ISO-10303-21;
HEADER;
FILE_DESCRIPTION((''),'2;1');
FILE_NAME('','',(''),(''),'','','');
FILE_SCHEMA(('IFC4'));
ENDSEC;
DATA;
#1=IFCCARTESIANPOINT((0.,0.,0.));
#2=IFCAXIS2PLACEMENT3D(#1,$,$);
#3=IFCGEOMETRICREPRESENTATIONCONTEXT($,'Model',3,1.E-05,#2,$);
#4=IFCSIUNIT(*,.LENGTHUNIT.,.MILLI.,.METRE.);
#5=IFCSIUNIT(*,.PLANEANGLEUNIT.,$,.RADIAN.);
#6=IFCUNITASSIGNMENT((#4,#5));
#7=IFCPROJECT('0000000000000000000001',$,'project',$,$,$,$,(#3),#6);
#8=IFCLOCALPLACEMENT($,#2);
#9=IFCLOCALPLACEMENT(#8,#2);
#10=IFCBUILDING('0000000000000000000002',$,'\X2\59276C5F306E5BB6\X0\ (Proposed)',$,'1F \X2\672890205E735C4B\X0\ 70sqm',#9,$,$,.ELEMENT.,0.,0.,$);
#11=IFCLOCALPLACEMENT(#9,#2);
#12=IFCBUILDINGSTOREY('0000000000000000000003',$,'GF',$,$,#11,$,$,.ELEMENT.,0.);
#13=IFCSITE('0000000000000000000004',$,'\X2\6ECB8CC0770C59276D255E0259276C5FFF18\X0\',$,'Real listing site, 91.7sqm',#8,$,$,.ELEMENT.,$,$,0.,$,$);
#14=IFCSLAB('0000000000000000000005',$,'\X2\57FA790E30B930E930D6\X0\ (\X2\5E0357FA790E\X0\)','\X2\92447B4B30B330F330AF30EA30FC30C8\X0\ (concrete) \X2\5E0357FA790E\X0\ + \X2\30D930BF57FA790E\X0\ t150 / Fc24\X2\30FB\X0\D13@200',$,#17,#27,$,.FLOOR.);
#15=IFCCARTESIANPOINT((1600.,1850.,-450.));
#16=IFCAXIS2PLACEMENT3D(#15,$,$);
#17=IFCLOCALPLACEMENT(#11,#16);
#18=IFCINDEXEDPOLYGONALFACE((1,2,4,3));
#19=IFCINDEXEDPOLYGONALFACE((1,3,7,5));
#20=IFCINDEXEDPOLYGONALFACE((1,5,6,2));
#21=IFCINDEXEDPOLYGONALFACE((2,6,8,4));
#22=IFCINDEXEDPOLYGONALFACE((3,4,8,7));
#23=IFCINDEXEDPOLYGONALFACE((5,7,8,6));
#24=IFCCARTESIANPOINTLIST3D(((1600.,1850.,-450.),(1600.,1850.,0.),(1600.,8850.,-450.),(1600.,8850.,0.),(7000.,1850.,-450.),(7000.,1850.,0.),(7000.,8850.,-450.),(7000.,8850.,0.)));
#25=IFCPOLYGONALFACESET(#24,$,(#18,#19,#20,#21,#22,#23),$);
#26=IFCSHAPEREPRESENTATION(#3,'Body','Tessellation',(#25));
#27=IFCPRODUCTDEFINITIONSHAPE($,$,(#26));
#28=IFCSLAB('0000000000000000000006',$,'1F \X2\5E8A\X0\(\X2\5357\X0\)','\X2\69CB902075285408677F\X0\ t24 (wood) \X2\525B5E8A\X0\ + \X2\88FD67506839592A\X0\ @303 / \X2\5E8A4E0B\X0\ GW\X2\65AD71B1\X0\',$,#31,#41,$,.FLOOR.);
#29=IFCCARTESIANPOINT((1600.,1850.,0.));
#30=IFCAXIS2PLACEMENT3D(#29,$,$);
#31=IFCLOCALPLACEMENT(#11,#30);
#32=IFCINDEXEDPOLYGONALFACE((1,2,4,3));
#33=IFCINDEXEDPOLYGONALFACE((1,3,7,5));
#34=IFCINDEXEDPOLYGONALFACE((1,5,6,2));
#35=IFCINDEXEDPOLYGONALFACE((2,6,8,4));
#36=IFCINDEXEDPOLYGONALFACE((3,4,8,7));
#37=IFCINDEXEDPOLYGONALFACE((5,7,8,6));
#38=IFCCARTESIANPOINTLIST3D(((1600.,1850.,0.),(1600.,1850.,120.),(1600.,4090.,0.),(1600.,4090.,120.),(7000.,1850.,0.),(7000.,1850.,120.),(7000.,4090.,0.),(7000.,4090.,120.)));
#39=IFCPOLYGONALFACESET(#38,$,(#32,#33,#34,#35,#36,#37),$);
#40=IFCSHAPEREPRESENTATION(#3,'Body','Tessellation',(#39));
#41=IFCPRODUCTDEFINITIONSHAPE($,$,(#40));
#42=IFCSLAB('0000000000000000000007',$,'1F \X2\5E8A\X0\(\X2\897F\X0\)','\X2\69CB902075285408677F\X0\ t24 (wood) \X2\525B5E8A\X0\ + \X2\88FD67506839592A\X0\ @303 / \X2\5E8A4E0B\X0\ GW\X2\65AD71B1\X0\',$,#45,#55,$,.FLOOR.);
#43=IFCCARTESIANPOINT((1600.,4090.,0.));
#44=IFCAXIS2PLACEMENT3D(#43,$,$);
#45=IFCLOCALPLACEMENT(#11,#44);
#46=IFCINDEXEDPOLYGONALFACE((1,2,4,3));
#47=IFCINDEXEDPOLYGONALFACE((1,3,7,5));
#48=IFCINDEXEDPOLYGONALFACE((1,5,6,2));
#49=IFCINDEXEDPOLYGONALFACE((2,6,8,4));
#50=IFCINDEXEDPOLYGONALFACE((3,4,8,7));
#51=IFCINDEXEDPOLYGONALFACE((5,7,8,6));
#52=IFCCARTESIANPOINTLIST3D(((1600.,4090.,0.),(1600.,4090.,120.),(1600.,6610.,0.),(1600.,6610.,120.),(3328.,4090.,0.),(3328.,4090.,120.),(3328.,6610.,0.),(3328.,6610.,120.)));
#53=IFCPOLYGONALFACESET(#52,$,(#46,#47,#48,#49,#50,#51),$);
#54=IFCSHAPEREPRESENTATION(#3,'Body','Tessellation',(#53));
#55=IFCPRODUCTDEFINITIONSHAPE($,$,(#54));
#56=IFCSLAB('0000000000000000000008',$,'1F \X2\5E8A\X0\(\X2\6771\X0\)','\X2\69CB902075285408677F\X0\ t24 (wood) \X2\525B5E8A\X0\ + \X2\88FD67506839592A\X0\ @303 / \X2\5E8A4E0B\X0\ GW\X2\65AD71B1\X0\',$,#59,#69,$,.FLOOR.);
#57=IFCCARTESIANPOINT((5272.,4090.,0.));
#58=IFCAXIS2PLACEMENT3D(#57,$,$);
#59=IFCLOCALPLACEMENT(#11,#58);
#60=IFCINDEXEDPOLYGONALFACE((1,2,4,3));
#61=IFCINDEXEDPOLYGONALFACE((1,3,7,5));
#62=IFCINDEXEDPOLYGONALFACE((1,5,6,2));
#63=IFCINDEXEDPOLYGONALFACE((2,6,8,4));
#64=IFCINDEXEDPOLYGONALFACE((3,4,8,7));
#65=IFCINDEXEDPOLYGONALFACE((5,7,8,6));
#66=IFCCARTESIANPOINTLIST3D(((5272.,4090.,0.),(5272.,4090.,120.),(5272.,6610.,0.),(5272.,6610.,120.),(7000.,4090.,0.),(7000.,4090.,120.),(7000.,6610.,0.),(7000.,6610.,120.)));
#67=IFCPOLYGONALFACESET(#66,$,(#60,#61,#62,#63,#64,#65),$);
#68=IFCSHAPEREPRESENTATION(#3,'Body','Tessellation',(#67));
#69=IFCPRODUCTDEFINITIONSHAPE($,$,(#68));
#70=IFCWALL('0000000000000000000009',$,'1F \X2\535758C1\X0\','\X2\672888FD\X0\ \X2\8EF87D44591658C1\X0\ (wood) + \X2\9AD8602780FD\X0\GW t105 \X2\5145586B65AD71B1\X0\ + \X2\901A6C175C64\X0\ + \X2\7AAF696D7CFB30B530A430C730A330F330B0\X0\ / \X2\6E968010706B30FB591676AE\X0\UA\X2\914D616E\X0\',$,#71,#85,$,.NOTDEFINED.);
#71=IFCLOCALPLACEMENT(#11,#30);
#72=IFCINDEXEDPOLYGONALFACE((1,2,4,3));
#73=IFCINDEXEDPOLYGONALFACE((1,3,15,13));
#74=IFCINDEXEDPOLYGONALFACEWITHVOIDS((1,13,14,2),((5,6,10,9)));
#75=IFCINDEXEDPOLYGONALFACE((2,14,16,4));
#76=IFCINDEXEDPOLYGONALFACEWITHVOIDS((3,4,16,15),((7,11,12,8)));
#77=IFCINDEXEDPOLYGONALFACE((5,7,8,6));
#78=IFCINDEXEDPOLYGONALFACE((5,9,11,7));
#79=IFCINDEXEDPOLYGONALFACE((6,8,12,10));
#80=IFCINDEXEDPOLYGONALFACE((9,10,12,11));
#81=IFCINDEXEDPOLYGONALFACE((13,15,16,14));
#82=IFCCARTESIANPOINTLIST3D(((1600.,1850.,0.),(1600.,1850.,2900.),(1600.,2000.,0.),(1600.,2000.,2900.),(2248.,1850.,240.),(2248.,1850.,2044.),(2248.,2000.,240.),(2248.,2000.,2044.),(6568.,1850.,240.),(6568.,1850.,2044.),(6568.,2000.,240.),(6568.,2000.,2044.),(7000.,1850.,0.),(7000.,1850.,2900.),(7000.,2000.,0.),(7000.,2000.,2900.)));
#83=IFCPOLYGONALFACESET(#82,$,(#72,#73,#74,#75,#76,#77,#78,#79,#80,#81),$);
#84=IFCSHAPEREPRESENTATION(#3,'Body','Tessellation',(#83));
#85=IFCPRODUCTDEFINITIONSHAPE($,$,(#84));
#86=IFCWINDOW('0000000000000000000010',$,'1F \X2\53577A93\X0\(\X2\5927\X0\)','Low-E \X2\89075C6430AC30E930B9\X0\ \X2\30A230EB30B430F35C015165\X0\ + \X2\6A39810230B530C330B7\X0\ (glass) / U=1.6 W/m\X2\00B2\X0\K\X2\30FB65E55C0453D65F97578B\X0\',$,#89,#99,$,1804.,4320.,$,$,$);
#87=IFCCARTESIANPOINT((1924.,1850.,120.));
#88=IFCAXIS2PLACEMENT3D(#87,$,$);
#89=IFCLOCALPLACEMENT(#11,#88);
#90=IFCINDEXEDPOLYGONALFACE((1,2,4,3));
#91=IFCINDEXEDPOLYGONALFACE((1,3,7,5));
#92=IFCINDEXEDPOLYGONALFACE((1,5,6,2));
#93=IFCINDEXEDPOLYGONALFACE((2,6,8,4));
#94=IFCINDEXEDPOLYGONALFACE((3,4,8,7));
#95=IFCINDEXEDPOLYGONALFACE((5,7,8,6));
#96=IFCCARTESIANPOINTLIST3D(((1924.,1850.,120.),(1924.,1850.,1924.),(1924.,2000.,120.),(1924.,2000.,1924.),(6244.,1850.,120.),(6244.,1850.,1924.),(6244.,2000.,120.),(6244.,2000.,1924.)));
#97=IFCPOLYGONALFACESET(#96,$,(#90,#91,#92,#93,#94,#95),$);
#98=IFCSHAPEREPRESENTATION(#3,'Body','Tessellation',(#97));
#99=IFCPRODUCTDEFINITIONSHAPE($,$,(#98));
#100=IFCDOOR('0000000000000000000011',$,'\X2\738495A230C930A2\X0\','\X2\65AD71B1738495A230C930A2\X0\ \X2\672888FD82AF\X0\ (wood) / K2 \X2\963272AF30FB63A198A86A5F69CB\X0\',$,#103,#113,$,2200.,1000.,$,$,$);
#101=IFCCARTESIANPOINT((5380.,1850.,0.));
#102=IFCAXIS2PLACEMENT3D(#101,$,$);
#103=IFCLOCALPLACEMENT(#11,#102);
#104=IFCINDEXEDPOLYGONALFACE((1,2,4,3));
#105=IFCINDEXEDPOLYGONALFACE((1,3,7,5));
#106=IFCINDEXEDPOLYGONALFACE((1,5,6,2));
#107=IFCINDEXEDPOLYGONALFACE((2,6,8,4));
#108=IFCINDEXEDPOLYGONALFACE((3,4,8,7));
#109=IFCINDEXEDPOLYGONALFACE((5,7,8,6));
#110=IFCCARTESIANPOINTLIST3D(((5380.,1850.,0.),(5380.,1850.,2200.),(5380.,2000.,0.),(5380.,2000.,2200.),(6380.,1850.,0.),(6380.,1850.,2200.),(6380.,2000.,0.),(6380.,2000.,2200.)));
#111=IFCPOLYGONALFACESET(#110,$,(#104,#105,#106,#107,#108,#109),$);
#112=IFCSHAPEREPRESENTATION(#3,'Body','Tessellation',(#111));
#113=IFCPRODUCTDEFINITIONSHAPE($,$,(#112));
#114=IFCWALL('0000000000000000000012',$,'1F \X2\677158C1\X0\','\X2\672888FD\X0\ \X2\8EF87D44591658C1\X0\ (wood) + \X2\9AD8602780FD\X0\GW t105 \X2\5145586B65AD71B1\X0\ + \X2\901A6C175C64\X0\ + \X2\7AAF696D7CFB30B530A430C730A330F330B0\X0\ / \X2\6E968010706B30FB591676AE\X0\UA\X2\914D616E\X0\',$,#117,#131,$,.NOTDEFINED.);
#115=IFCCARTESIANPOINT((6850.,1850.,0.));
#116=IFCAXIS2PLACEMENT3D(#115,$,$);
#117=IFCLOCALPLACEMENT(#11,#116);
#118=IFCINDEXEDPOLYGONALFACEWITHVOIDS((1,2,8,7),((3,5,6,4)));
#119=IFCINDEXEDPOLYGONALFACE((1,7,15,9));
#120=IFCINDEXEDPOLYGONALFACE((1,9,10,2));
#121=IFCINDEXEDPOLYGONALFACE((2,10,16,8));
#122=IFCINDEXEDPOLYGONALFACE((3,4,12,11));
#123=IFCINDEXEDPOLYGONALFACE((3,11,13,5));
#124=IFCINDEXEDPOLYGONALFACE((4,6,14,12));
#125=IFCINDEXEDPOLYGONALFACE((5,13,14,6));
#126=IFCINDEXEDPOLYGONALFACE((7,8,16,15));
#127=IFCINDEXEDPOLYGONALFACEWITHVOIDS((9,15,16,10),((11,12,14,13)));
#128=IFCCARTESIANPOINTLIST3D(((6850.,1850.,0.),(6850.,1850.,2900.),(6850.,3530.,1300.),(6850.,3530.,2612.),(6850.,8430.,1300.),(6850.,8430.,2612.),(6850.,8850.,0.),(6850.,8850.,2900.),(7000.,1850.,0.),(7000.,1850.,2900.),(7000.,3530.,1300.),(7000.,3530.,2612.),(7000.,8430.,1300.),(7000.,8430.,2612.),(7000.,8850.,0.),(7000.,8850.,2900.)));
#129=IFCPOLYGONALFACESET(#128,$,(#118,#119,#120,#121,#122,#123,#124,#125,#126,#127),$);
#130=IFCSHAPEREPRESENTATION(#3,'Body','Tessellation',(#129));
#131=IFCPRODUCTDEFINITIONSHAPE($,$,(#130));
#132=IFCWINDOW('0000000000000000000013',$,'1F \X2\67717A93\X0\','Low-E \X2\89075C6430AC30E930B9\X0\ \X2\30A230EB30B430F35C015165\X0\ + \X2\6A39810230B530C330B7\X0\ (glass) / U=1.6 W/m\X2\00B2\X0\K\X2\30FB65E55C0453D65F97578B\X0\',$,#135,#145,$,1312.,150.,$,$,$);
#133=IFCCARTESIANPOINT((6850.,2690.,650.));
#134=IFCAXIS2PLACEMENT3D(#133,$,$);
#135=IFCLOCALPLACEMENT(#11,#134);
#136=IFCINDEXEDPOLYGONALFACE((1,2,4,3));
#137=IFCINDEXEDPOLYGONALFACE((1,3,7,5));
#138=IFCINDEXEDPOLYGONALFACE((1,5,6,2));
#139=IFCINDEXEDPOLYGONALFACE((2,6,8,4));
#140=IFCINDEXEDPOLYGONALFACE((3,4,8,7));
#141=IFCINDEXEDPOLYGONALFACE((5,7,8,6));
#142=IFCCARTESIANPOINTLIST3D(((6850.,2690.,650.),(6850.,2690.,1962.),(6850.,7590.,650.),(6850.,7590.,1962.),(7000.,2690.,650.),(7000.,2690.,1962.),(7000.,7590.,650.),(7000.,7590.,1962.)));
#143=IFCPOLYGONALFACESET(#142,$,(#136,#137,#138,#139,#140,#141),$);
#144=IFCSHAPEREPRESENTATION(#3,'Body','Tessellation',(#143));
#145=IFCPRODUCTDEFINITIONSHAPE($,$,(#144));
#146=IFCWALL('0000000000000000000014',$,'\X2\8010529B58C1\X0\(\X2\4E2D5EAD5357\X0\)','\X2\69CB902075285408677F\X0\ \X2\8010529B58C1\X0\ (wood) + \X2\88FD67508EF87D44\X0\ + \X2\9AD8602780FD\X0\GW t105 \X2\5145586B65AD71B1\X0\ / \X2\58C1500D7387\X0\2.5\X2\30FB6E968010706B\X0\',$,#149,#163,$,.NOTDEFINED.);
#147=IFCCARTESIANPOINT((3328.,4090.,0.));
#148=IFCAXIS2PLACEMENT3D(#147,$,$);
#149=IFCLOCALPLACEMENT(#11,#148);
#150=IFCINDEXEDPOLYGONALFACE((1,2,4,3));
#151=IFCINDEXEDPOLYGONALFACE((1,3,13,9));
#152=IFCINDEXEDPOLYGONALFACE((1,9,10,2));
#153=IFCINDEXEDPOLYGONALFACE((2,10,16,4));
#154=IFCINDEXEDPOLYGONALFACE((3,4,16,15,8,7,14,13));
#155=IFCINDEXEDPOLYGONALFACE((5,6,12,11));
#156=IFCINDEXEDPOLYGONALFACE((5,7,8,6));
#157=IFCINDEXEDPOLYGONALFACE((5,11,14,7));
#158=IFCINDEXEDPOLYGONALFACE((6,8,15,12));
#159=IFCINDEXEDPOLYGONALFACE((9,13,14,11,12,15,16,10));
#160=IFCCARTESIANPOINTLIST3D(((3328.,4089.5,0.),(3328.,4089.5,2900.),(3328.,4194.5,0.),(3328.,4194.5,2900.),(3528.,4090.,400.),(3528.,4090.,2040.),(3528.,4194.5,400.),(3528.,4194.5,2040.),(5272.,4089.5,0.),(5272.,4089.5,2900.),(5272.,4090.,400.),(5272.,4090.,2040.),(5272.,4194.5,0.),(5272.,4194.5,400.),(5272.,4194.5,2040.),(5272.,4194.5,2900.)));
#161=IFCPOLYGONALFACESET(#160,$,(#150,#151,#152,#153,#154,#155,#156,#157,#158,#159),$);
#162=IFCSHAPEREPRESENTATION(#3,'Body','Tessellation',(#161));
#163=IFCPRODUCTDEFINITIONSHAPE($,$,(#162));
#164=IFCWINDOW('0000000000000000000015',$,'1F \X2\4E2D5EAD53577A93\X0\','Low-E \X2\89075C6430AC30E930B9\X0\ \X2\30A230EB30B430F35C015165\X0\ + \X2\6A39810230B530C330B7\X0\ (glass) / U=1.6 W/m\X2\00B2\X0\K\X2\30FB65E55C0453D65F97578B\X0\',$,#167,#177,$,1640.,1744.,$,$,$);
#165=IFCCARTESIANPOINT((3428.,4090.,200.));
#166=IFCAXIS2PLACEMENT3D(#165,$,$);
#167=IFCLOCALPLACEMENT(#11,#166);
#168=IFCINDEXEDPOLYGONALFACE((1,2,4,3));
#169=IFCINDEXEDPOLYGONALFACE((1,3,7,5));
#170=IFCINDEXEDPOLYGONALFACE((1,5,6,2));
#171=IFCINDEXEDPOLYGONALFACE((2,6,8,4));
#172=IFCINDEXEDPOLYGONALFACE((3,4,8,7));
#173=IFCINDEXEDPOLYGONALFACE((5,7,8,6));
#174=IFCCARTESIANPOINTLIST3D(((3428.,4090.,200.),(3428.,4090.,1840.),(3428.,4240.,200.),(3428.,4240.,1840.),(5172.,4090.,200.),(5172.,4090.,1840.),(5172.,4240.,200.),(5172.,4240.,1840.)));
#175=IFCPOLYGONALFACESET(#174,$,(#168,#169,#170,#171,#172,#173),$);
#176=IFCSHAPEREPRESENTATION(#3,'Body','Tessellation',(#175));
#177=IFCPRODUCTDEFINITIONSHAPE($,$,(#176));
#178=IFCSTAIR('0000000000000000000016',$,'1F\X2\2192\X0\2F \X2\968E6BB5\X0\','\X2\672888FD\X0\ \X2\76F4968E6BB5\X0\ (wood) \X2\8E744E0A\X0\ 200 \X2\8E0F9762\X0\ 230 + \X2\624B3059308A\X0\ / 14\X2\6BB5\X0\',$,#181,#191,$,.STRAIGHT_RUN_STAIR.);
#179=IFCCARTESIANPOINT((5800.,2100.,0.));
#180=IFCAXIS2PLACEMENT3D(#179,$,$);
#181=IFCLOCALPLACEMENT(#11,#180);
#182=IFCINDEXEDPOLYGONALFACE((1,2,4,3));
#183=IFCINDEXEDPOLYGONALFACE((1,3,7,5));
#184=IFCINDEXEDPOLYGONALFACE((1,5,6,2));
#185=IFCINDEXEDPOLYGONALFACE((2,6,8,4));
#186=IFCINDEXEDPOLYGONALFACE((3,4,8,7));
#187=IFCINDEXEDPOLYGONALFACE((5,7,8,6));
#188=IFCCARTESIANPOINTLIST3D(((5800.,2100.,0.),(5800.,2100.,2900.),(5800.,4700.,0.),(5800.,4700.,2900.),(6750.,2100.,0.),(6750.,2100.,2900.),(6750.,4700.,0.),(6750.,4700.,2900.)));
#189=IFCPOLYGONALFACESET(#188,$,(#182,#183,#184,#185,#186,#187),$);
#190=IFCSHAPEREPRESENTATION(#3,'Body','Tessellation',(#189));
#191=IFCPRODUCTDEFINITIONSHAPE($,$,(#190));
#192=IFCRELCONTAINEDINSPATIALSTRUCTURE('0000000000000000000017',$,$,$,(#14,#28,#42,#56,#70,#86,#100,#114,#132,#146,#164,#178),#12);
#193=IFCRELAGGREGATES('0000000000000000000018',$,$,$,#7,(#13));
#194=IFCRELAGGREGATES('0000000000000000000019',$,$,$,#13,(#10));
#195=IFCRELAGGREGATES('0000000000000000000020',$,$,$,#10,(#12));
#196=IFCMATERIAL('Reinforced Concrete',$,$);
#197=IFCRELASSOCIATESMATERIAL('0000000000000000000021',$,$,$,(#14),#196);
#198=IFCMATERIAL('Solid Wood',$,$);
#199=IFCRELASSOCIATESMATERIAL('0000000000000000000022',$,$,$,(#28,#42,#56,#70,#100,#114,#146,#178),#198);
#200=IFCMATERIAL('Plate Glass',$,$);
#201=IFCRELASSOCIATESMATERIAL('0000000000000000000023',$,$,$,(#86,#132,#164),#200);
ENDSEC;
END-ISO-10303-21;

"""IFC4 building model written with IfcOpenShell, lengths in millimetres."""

from ifc_helpers import new_model, si_unit, frame, frame_2d, origin, place, context, project, spatial, rectangle, extrude, material, element, fill, save


model = new_model("IFC4")

# Units and contexts
model_context = context("Model", 3, precision=1e-05, world=origin())
ifc_project = project(units=[si_unit("LENGTHUNIT", "METRE", prefix="MILLI"), si_unit("PLANEANGLEUNIT", "RADIAN")], contexts=[model_context])

# Site, building, storey
site_placement = place(None, origin())
site = spatial("IfcSite", under=ifc_project, at=site_placement, Name="滋賀県大津市大江８", ObjectType="Real listing site, 91.7sqm", CompositionType="ELEMENT", RefElevation=0.0)
building_placement = place(site_placement, origin())
building = spatial("IfcBuilding", under=site, at=building_placement, Name="大江の家 (Proposed)", ObjectType="1F 木造平屋 70sqm", CompositionType="ELEMENT", ElevationOfRefHeight=0.0, ElevationOfTerrain=0.0)
storey_placement = place(building_placement, origin())
storey = spatial("IfcBuildingStorey", under=building, at=storey_placement, Name="GF", CompositionType="ELEMENT", Elevation=0.0)

# Slabs
ifc_material_1 = material(Name="Reinforced Concrete")
slab_1_placement = place(storey_placement, frame((1600.0, 1850.0, -450.0)))
element("IfcSlab", 1, at=slab_1_placement, inside=storey, material=ifc_material_1, Name="基礎スラブ (布基礎)", Description="鉄筋コンクリート (concrete) 布基礎 + ベタ基礎 t150 / Fc24・D13@200", PredefinedType="FLOOR", context=model_context, shape_type="SweptSolid", body=[
    extrude(rectangle(XDim=5400.0, YDim=7000.0, at=frame_2d((2700.0, 3500.0))), frame((1600.0, 1850.0, -450.0)), (0.0, 0.0, 1.0), 450.0),
])
ifc_material_2 = material(Name="Solid Wood")
slab_2_placement = place(storey_placement, frame((1600.0, 1850.0, 0.0)))
element("IfcSlab", 2, at=slab_2_placement, inside=storey, material=ifc_material_2, Name="1F 床(南)", Description="構造用合板 t24 (wood) 剛床 + 製材根太 @303 / 床下 GW断熱", PredefinedType="FLOOR", context=model_context, shape_type="SweptSolid", body=[
    extrude(rectangle(XDim=5400.0, YDim=2240.0, at=frame_2d((2700.0, 1120.0))), frame((1600.0, 1850.0, 0.0)), (0.0, 0.0, 1.0), 120.0),
])
slab_3_placement = place(storey_placement, frame((1600.0, 4090.0, 0.0)))
element("IfcSlab", 3, at=slab_3_placement, inside=storey, material=ifc_material_2, Name="1F 床(西)", Description="構造用合板 t24 (wood) 剛床 + 製材根太 @303 / 床下 GW断熱", PredefinedType="FLOOR", context=model_context, shape_type="SweptSolid", body=[
    extrude(rectangle(XDim=1728.0, YDim=2520.0, at=frame_2d((864.0, 1260.0))), frame((1600.0, 4090.0, 0.0)), (0.0, 0.0, 1.0), 120.0),
])
slab_4_placement = place(storey_placement, frame((5272.0, 4090.0, 0.0)))
element("IfcSlab", 4, at=slab_4_placement, inside=storey, material=ifc_material_2, Name="1F 床(東)", Description="構造用合板 t24 (wood) 剛床 + 製材根太 @303 / 床下 GW断熱", PredefinedType="FLOOR", context=model_context, shape_type="SweptSolid", body=[
    extrude(rectangle(XDim=1728.0, YDim=2520.0, at=frame_2d((864.0, 1260.0))), frame((5272.0, 4090.0, 0.0)), (0.0, 0.0, 1.0), 120.0),
])

# Wall, openings, window, door
wall_1_placement = place(storey_placement, frame((1600.0, 1850.0, 0.0)))
wall_1 = element("IfcWall", 5, at=wall_1_placement, inside=storey, material=ifc_material_2, Name="1F 南壁", Description="木製 軸組外壁 (wood) + 高性能GW t105 充填断熱 + 通気層 + 窯業系サイディング / 準耐火・外皮UA配慮", PredefinedType="NOTDEFINED", context=model_context, shape_type="SweptSolid", body=[
    extrude(rectangle(XDim=5400.0, YDim=150.0, at=frame_2d((2700.0, 75.0))), frame((1600.0, 1850.0, 0.0)), (0.0, 0.0, 1.0), 2900.0),
])
opening_1_placement = place(storey_placement, frame((1924.0, 1850.0, 120.0)))
opening_1 = element("IfcOpeningElement", 6, at=opening_1_placement, cuts=wall_1, PredefinedType="NOTDEFINED", context=model_context, shape_type="SweptSolid", body=[
    extrude(rectangle(XDim=4320.0, YDim=150.0, at=frame_2d((2160.0, 75.0))), frame((1924.0, 1850.0, 120.0)), (0.0, 0.0, 1.0), 1804.0),
])
opening_2_placement = place(storey_placement, frame((5380.0, 1850.0, 0.0)))
opening_2 = element("IfcOpeningElement", 7, at=opening_2_placement, cuts=wall_1, PredefinedType="NOTDEFINED", context=model_context, shape_type="SweptSolid", body=[
    extrude(rectangle(XDim=1000.0, YDim=150.0, at=frame_2d((500.0, 75.0))), frame((5380.0, 1850.0, 0.0)), (0.0, 0.0, 1.0), 2200.0),
])
ifc_material_3 = material(Name="Plate Glass")
window_1_placement = place(storey_placement, frame((1924.0, 1850.0, 120.0)))
window_1 = element("IfcWindow", 8, at=window_1_placement, inside=storey, material=ifc_material_3, Name="1F 南窓(大)", Description="Low-E 複層ガラス アルゴン封入 + 樹脂サッシ (glass) / U=1.6 W/m²K・日射取得型", OverallHeight=1804.0, OverallWidth=4320.0, context=model_context, shape_type="SweptSolid", body=[
    extrude(rectangle(XDim=4320.0, YDim=150.0, at=frame_2d((2160.0, 75.0))), frame((1924.0, 1850.0, 120.0)), (0.0, 0.0, 1.0), 1804.0),
])
fill(opening_1, window_1)
door_placement = place(storey_placement, frame((5380.0, 1850.0, 0.0)))
door = element("IfcDoor", 9, at=door_placement, inside=storey, material=ifc_material_2, Name="玄関ドア", Description="断熱玄関ドア 木製芯 (wood) / K2 防犯・採風機構", OverallHeight=2200.0, OverallWidth=1000.0, context=model_context, shape_type="SweptSolid", body=[
    extrude(rectangle(XDim=1000.0, YDim=150.0, at=frame_2d((500.0, 75.0))), frame((5380.0, 1850.0, 0.0)), (0.0, 0.0, 1.0), 2200.0),
])
fill(opening_2, door)

# Walls, openings, windows
wall_2_placement = place(storey_placement, frame((6850.0, 1850.0, 0.0)))
wall_2 = element("IfcWall", 10, at=wall_2_placement, inside=storey, material=ifc_material_2, Name="1F 東壁", Description="木製 軸組外壁 (wood) + 高性能GW t105 充填断熱 + 通気層 + 窯業系サイディング / 準耐火・外皮UA配慮", PredefinedType="NOTDEFINED", context=model_context, shape_type="SweptSolid", body=[
    extrude(rectangle(XDim=150.0, YDim=7000.0, at=frame_2d((75.0, 3500.0))), frame((6850.0, 1850.0, 0.0)), (0.0, 0.0, 1.0), 2900.0),
])
opening_3_placement = place(storey_placement, frame((6850.0, 2690.0, 650.0)))
opening_3 = element("IfcOpeningElement", 11, at=opening_3_placement, cuts=wall_2, PredefinedType="NOTDEFINED", context=model_context, shape_type="SweptSolid", body=[
    extrude(rectangle(XDim=150.0, YDim=4900.0, at=frame_2d((75.0, 2450.0))), frame((6850.0, 2690.0, 650.0)), (0.0, 0.0, 1.0), 1312.0),
])
window_2_placement = place(storey_placement, frame((6850.0, 2690.0, 650.0)))
window_2 = element("IfcWindow", 12, at=window_2_placement, inside=storey, material=ifc_material_3, Name="1F 東窓", Description="Low-E 複層ガラス アルゴン封入 + 樹脂サッシ (glass) / U=1.6 W/m²K・日射取得型", OverallHeight=1312.0, OverallWidth=150.0, context=model_context, shape_type="SweptSolid", body=[
    extrude(rectangle(XDim=150.0, YDim=4900.0, at=frame_2d((75.0, 2450.0))), frame((6850.0, 2690.0, 650.0)), (0.0, 0.0, 1.0), 1312.0),
])
fill(opening_3, window_2)
wall_3_placement = place(storey_placement, frame((3328.0, 4090.0, 0.0)))
wall_3 = element("IfcWall", 13, at=wall_3_placement, inside=storey, material=ifc_material_2, Name="耐力壁(中庭南)", Description="構造用合板 耐力壁 (wood) + 製材軸組 + 高性能GW t105 充填断熱 / 壁倍率2.5・準耐火", PredefinedType="NOTDEFINED", context=model_context, shape_type="SweptSolid", body=[
    extrude(rectangle(XDim=1944.0, YDim=105.0, at=frame_2d((972.0, 52.0))), frame((3328.0, 4090.0, 0.0)), (0.0, 0.0, 1.0), 2900.0),
])
opening_4_placement = place(storey_placement, frame((3428.0, 4090.0, 200.0)))
opening_4 = element("IfcOpeningElement", 14, at=opening_4_placement, cuts=wall_3, PredefinedType="NOTDEFINED", context=model_context, shape_type="SweptSolid", body=[
    extrude(rectangle(XDim=1744.0, YDim=150.0, at=frame_2d((872.0, 75.0))), frame((3428.0, 4090.0, 200.0)), (0.0, 0.0, 1.0), 1640.0),
])
window_3_placement = place(storey_placement, frame((3428.0, 4090.0, 200.0)))
window_3 = element("IfcWindow", 15, at=window_3_placement, inside=storey, material=ifc_material_3, Name="1F 中庭南窓", Description="Low-E 複層ガラス アルゴン封入 + 樹脂サッシ (glass) / U=1.6 W/m²K・日射取得型", OverallHeight=1640.0, OverallWidth=1744.0, context=model_context, shape_type="SweptSolid", body=[
    extrude(rectangle(XDim=1744.0, YDim=150.0, at=frame_2d((872.0, 75.0))), frame((3428.0, 4090.0, 200.0)), (0.0, 0.0, 1.0), 1640.0),
])
fill(opening_4, window_3)

# Stair
stair_placement = place(storey_placement, frame((5800.0, 2100.0, 0.0)))
element("IfcStair", 16, at=stair_placement, inside=storey, material=ifc_material_2, Name="1F→2F 階段", Description="木製 直階段 (wood) 蹴上 200 踏面 230 + 手すり / 14段", PredefinedType="STRAIGHT_RUN_STAIR", context=model_context, shape_type="SweptSolid", body=[
    extrude(rectangle(XDim=950.0, YDim=2600.0, at=frame_2d((475.0, 1300.0))), frame((5800.0, 2100.0, 0.0)), (0.0, 0.0, 1.0), 2900.0),
])

save(model, "model.ifc")
